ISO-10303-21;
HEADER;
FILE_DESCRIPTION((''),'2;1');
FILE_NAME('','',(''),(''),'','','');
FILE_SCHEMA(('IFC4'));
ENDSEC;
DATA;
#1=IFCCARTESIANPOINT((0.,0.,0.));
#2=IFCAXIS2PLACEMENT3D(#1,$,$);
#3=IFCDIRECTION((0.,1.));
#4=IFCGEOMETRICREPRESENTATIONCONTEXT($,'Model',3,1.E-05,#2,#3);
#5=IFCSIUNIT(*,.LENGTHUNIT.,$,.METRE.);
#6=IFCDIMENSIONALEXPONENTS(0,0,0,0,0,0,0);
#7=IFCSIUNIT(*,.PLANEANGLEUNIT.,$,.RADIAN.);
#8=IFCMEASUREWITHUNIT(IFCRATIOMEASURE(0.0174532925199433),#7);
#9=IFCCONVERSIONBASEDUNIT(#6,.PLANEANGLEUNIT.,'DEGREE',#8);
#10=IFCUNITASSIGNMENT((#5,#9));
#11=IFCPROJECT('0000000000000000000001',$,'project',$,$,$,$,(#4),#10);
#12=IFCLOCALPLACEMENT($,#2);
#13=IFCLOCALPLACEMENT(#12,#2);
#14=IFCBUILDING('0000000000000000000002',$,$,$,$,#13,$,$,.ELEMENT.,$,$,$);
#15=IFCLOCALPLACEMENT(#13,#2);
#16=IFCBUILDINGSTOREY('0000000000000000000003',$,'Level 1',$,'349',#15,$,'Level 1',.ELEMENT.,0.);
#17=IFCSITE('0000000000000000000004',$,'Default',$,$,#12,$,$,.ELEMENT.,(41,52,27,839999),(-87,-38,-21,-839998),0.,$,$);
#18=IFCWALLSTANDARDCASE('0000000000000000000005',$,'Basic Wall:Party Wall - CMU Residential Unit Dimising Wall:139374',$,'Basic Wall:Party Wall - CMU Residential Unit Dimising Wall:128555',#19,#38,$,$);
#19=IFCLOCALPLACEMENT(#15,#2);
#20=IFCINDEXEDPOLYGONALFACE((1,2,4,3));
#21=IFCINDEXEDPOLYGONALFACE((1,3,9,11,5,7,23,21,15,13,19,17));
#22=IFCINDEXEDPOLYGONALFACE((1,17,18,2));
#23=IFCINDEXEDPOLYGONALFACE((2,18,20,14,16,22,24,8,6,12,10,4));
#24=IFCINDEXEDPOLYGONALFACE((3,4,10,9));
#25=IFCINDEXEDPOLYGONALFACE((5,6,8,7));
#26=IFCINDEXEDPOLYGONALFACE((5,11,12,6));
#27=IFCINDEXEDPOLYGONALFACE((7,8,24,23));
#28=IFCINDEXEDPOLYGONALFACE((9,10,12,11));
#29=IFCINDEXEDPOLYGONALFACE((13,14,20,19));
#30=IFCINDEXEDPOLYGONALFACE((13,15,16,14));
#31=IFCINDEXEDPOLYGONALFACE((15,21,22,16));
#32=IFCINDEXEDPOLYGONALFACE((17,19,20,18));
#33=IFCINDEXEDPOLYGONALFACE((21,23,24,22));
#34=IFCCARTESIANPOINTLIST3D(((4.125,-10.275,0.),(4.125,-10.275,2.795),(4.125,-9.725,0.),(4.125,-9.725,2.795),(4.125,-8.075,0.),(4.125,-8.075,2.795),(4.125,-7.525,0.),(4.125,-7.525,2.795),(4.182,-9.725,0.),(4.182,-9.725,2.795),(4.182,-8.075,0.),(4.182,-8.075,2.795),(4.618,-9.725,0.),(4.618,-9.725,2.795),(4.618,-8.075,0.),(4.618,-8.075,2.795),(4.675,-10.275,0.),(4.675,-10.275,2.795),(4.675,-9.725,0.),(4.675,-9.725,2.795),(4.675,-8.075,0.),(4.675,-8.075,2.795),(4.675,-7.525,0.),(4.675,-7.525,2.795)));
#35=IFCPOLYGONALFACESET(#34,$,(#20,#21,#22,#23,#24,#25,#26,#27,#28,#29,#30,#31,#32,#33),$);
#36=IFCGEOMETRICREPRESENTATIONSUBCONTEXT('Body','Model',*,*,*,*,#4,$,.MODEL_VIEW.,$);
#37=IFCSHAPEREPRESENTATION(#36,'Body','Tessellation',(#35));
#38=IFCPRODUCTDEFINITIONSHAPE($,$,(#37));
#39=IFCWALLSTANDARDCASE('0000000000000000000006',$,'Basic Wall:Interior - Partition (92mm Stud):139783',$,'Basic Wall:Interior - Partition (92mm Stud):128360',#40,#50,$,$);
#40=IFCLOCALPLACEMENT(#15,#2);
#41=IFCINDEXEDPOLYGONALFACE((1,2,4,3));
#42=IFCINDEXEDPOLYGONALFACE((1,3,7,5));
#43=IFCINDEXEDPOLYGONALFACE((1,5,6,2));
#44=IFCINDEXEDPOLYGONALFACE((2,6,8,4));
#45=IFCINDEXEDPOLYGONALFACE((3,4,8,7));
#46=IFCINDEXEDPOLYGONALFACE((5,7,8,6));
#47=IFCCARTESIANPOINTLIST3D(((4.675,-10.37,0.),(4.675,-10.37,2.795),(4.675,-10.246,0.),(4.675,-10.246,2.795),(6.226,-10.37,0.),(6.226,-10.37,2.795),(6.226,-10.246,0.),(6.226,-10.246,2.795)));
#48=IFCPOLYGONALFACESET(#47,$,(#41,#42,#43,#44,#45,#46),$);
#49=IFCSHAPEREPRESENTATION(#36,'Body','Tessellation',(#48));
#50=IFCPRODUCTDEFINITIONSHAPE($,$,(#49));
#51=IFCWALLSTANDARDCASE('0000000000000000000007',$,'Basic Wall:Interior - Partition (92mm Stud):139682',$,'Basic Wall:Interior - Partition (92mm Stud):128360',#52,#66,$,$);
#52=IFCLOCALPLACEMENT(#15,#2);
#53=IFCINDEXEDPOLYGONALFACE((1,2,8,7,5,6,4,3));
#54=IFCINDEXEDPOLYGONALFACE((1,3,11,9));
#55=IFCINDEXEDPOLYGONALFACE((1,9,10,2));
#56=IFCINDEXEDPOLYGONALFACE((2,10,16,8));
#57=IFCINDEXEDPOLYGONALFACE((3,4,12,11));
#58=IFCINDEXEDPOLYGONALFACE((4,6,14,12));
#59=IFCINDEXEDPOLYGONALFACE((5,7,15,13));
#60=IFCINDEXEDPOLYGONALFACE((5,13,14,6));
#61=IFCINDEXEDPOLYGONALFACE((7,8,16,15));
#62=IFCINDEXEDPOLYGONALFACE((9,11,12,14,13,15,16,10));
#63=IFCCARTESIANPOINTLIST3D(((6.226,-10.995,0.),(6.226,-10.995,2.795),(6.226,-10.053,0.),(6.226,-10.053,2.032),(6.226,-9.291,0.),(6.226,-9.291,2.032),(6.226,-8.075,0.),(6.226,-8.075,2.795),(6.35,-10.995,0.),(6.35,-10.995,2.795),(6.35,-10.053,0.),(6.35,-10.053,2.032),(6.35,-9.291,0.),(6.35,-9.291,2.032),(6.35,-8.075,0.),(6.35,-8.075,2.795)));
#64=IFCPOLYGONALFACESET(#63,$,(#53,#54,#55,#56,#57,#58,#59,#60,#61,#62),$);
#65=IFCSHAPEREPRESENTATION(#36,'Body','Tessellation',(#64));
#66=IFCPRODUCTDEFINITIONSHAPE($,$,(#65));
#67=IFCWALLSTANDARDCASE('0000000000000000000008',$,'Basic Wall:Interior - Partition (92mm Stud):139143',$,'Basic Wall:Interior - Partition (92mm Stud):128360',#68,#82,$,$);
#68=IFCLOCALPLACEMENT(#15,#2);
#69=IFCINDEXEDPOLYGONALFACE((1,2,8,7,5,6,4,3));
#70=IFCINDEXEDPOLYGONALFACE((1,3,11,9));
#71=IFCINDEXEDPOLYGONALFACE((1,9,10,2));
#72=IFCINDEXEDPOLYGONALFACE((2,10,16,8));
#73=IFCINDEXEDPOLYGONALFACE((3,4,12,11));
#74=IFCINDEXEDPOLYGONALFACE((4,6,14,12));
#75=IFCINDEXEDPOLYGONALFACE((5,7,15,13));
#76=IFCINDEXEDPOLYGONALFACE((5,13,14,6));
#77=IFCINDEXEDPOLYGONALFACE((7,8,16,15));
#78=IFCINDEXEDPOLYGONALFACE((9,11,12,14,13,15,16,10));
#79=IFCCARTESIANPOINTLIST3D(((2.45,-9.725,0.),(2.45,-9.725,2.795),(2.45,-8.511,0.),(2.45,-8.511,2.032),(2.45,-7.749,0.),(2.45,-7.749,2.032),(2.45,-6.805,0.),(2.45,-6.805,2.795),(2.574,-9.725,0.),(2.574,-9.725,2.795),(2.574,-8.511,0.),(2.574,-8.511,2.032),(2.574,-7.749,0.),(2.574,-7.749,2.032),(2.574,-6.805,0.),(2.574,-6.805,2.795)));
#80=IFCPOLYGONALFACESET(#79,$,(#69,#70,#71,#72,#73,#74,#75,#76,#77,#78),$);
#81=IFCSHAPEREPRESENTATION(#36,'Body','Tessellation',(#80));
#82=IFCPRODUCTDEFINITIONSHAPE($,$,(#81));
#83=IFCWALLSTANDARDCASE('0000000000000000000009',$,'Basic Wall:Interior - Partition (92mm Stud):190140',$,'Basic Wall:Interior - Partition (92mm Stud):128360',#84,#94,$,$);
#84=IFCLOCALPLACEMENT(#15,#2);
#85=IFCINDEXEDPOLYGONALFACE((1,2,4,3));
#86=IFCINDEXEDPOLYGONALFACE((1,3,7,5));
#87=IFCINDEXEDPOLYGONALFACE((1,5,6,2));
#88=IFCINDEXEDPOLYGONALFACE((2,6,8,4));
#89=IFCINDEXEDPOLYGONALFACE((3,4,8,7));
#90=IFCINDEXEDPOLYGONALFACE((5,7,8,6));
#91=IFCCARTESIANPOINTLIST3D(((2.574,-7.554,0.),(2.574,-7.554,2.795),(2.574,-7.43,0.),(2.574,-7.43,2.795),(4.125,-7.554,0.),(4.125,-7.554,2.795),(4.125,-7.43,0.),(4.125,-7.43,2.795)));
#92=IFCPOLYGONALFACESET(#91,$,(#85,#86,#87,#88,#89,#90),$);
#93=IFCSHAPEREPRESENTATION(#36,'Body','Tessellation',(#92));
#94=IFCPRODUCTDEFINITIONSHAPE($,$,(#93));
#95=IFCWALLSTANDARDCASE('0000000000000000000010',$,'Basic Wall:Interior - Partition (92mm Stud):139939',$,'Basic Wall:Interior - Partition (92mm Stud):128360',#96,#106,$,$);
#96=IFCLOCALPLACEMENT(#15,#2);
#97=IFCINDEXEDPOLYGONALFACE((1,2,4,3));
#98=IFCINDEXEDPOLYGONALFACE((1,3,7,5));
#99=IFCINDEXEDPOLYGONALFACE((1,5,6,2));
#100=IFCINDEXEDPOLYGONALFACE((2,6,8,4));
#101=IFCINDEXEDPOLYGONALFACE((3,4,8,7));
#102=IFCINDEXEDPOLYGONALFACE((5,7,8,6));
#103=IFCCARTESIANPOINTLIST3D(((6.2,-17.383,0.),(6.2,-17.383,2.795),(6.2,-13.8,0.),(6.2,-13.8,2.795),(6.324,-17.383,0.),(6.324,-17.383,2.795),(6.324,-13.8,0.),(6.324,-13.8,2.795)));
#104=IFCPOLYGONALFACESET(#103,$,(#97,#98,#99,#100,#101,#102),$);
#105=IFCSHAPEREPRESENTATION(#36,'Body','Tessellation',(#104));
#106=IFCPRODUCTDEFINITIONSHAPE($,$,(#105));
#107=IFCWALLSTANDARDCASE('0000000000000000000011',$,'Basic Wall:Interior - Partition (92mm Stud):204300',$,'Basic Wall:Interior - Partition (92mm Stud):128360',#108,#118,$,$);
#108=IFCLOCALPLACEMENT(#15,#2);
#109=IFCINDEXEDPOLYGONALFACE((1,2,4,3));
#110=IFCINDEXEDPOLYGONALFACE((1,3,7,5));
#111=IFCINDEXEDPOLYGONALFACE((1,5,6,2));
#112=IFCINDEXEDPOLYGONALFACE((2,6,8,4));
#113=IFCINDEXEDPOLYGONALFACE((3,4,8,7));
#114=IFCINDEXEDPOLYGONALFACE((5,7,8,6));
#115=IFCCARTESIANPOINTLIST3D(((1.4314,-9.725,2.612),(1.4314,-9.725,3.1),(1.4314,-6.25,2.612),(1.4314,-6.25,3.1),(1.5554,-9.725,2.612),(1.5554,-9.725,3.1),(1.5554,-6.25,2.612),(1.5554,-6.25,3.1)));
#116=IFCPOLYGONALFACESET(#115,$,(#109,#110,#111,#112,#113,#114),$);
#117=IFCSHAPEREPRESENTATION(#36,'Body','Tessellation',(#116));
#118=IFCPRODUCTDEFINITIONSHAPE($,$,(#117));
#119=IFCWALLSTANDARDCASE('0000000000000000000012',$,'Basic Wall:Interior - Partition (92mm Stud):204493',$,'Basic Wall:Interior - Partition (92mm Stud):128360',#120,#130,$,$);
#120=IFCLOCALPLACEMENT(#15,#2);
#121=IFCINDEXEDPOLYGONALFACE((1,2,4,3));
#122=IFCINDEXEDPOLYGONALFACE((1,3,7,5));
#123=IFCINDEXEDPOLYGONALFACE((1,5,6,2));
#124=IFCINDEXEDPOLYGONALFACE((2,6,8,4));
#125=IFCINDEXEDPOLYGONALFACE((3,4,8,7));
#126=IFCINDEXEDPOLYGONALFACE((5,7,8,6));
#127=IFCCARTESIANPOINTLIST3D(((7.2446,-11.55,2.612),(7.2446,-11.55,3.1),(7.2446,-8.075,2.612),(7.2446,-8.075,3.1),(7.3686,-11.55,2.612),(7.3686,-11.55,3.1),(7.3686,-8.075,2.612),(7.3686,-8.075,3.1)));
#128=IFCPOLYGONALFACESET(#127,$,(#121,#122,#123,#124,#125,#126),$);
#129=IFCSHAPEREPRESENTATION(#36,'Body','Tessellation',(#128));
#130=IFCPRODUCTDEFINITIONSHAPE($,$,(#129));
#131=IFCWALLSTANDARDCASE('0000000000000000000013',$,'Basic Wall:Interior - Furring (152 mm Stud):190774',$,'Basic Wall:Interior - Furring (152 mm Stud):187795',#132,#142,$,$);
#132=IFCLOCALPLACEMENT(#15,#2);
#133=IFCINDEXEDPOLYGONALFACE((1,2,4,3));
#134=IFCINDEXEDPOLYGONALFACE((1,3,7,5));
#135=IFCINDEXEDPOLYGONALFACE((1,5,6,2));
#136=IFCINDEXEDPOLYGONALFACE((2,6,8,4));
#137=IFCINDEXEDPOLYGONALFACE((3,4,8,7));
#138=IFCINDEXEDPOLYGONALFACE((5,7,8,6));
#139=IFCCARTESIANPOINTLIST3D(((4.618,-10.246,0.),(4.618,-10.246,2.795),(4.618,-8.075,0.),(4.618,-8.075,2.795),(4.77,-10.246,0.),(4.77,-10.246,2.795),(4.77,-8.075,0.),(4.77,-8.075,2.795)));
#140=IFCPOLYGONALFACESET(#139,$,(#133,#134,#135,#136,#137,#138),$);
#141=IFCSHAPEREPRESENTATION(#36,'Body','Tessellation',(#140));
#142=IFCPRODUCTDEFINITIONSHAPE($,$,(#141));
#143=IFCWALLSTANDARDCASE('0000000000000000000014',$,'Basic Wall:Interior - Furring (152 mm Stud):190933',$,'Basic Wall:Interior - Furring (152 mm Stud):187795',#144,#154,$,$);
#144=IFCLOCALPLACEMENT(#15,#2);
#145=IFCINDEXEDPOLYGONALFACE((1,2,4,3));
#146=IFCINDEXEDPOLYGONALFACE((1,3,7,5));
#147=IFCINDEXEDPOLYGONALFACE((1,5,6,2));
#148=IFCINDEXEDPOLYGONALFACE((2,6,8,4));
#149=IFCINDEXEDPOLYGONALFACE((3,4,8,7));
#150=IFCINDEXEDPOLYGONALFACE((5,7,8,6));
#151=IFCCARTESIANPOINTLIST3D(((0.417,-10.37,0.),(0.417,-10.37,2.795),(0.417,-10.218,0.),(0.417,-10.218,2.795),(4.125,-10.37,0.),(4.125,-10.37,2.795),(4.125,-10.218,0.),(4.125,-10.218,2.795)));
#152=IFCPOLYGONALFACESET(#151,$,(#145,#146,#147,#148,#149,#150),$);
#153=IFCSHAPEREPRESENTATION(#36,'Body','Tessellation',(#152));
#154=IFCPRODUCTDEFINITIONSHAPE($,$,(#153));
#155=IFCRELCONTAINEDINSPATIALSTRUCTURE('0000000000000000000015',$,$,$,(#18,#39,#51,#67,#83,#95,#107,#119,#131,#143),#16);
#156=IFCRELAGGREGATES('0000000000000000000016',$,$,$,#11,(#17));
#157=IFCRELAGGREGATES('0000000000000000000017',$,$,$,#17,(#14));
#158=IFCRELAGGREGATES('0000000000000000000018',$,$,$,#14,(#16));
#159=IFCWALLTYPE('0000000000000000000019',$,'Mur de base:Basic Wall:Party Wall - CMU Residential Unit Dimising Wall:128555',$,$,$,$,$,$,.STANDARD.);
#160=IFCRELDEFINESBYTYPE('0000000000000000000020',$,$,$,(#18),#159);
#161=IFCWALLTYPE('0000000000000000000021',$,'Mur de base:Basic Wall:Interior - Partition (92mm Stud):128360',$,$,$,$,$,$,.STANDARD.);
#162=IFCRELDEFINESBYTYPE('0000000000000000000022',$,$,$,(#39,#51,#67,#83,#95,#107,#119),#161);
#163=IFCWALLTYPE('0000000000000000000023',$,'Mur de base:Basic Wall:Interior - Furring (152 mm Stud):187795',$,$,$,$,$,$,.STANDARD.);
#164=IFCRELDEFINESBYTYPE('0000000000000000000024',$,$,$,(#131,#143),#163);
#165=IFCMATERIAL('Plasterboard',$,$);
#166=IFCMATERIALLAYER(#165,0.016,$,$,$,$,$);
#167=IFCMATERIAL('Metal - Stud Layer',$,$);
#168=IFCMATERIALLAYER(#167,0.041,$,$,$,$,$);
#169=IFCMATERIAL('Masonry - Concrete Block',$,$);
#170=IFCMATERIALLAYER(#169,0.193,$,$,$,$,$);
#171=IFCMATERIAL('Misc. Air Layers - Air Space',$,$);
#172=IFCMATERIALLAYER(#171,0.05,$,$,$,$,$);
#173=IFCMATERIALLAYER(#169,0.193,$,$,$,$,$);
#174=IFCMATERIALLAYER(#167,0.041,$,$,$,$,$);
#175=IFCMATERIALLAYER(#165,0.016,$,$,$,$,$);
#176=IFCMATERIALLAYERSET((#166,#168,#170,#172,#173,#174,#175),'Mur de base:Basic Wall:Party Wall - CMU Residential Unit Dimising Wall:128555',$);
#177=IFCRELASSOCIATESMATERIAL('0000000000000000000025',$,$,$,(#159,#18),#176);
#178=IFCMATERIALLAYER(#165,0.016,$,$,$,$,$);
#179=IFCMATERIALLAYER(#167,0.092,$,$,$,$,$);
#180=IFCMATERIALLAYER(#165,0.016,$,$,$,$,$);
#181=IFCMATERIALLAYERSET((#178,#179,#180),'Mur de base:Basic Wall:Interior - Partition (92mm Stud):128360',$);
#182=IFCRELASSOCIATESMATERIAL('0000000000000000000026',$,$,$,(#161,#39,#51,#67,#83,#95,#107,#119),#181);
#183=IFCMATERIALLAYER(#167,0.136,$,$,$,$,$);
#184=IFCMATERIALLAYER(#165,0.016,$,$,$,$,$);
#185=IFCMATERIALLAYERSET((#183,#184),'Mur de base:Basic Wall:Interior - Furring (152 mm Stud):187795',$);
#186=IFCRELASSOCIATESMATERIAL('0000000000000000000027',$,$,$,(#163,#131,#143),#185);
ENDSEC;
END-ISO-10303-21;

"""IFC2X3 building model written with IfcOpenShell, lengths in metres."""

from ifc_helpers import new_model, entity, si_unit, converted_unit, direction, frame, frame_2d, origin, origin_2d_with_axis, place, context, subcontext, project, spatial, rectangle, extrude, material, layer, layer_set, layer_usage, type_object, element, save


model = new_model("IFC2X3")

# Units and contexts
model_context = context("Model", 3, precision=1e-05, world=origin(), true_north=direction((0.0, 1.0)))
body_context = subcontext(model_context, "Body", "Model", "MODEL_VIEW")
ifc_project = project(units=[si_unit("LENGTHUNIT", "METRE"), converted_unit("PLANEANGLEUNIT", "DEGREE", entity("IfcRatioMeasure", 0.0174532925199433), si_unit("PLANEANGLEUNIT", "RADIAN"), dimensions=[0, 0, 0, 0, 0, 0, 0])], contexts=[model_context])

# Site, building, storey
site_placement = place(None, origin())
site = spatial("IfcSite", under=ifc_project, at=site_placement, Name="Default", CompositionType="ELEMENT", RefLatitude=(41, 52, 27, 839999), RefLongitude=(-87, -38, -21, -839998), RefElevation=0.0)
building_placement = place(site_placement, origin())
building = spatial("IfcBuilding", under=site, at=building_placement, CompositionType="ELEMENT")
storey_placement = place(building_placement, origin())
storey = spatial("IfcBuildingStorey", under=building, at=storey_placement, Name="Level 1", ObjectType="349", LongName="Level 1", CompositionType="ELEMENT", Elevation=0.0)

# Wall, opening
ifc_material_1 = material(Name="Plasterboard")
ifc_layer_1 = layer(ifc_material_1, 0.016)
ifc_material_2 = material(Name="Metal - Stud Layer")
ifc_layer_2 = layer(ifc_material_2, 0.041)
ifc_material_3 = material(Name="Masonry - Concrete Block")
ifc_layer_3 = layer(ifc_material_3, 0.193)
ifc_material_4 = material(Name="Misc. Air Layers - Air Space")
ifc_layer_4 = layer(ifc_material_4, 0.05)
ifc_layer_5 = layer(ifc_material_3, 0.193)
ifc_layer_6 = layer(ifc_material_2, 0.041)
ifc_layer_7 = layer(ifc_material_1, 0.016)
ifc_layer_set_1 = layer_set([ifc_layer_1, ifc_layer_2, ifc_layer_3, ifc_layer_4, ifc_layer_5, ifc_layer_6, ifc_layer_7], Name="Mur de base:Basic Wall:Party Wall - CMU Residential Unit Dimising Wall:128555")
ifc_layer_usage_1 = layer_usage(ifc_layer_set_1, "AXIS2", "NEGATIVE", 0.275)
wall_type_1 = type_object("IfcWallType", Name="Mur de base:Basic Wall:Party Wall - CMU Residential Unit Dimising Wall:128555", PredefinedType="STANDARD", material=ifc_layer_set_1)
wall_1_placement = place(storey_placement, frame((4.4, -10.275, 0.0), z_axis=(0.0, 0.0, 1.0), x_axis=(0.0, 1.0, 0.0)))
wall_1 = element("IfcWallStandardCase", 1, at=wall_1_placement, inside=storey, type_object=wall_type_1, material=ifc_layer_usage_1, Name="Basic Wall:Party Wall - CMU Residential Unit Dimising Wall:139374", ObjectType="Basic Wall:Party Wall - CMU Residential Unit Dimising Wall:128555", context=body_context, shape_type="SweptSolid", body=[
    extrude(rectangle(XDim=2.75, YDim=0.55, at=frame_2d((1.375, 0.0), x_axis=(-1.0, 0.0))), origin(), (0.0, 0.0, 1.0), 2.795),
])
opening_1_placement = place(wall_1_placement, origin())
element("IfcOpeningElement", 2, at=opening_1_placement, cuts=wall_1, ObjectType="Opening", context=body_context, shape_type="SweptSolid", body=[
    extrude(rectangle(XDim=2.795, YDim=1.65, at=origin_2d_with_axis()), frame((1.375, 0.218, 1.3975), z_axis=(0.0, 1.0, 0.0), x_axis=(0.0, 0.0, 1.0)), (0.0, 0.0, 1.0), 3.904),
    extrude(rectangle(XDim=2.795, YDim=1.65, at=frame_2d((0.0, 0.0), x_axis=(0.0, 1.0))), frame((1.375, -4.122, 1.3975), z_axis=(0.0, 1.0, 0.0), x_axis=(-1.0, 0.0, 0.0)), (0.0, 0.0, 1.0), 3.904),
])

# Wall
ifc_layer_8 = layer(ifc_material_1, 0.016)
ifc_layer_9 = layer(ifc_material_2, 0.092)
ifc_layer_10 = layer(ifc_material_1, 0.016)
ifc_layer_set_2 = layer_set([ifc_layer_8, ifc_layer_9, ifc_layer_10], Name="Mur de base:Basic Wall:Interior - Partition (92mm Stud):128360")
ifc_layer_usage_2 = layer_usage(ifc_layer_set_2, "AXIS2", "NEGATIVE", 0.062)
wall_type_2 = type_object("IfcWallType", Name="Mur de base:Basic Wall:Interior - Partition (92mm Stud):128360", PredefinedType="STANDARD", material=ifc_layer_set_2)
wall_2_placement = place(storey_placement, frame((4.675, -10.308, 0.0)))
element("IfcWallStandardCase", 3, at=wall_2_placement, inside=storey, type_object=wall_type_2, material=ifc_layer_usage_2, Name="Basic Wall:Interior - Partition (92mm Stud):139783", ObjectType="Basic Wall:Interior - Partition (92mm Stud):128360", context=body_context, shape_type="SweptSolid", body=[
    extrude(rectangle(XDim=1.551, YDim=0.124, at=frame_2d((0.7755, 0.0), x_axis=(-1.0, 0.0))), origin(), (0.0, 0.0, 1.0), 2.795),
])

# Walls, openings
ifc_layer_usage_3 = layer_usage(ifc_layer_set_2, "AXIS2", "NEGATIVE", 0.062)
wall_3_placement = place(storey_placement, frame((6.288, -10.995, 0.0), z_axis=(0.0, 0.0, 1.0), x_axis=(0.0, 1.0, 0.0)))
wall_3 = element("IfcWallStandardCase", 4, at=wall_3_placement, inside=storey, type_object=wall_type_2, material=ifc_layer_usage_3, Name="Basic Wall:Interior - Partition (92mm Stud):139682", ObjectType="Basic Wall:Interior - Partition (92mm Stud):128360", context=body_context, shape_type="SweptSolid", body=[
    extrude(rectangle(XDim=2.92, YDim=0.124, at=frame_2d((1.46, 0.0), x_axis=(-1.0, 0.0))), origin(), (0.0, 0.0, 1.0), 2.795),
])
opening_2_placement = place(wall_3_placement, origin())
element("IfcOpeningElement", 5, at=opening_2_placement, cuts=wall_3, ObjectType="Opening", context=body_context, shape_type="SweptSolid", body=[
    extrude(rectangle(XDim=2.032, YDim=0.762, at=origin_2d_with_axis()), frame((1.323, -0.0632, 1.016), z_axis=(0.0, 1.0, 0.0), x_axis=(0.0, 0.0, 1.0)), (0.0, 0.0, 1.0), 0.1265),
])
ifc_layer_usage_4 = layer_usage(ifc_layer_set_2, "AXIS2", "NEGATIVE", 0.062)
wall_4_placement = place(storey_placement, frame((2.512, -6.805, 0.0), z_axis=(0.0, 0.0, 1.0), x_axis=(0.0, -1.0, 0.0)))
wall_4 = element("IfcWallStandardCase", 6, at=wall_4_placement, inside=storey, type_object=wall_type_2, material=ifc_layer_usage_4, Name="Basic Wall:Interior - Partition (92mm Stud):139143", ObjectType="Basic Wall:Interior - Partition (92mm Stud):128360", context=body_context, shape_type="SweptSolid", body=[
    extrude(rectangle(XDim=2.92, YDim=0.124, at=frame_2d((1.46, 0.0), x_axis=(-1.0, 0.0))), origin(), (0.0, 0.0, 1.0), 2.795),
])
opening_3_placement = place(wall_4_placement, origin())
element("IfcOpeningElement", 7, at=opening_3_placement, cuts=wall_4, ObjectType="Opening", context=body_context, shape_type="SweptSolid", body=[
    extrude(rectangle(XDim=2.032, YDim=0.762, at=origin_2d_with_axis()), frame((1.325, -0.0632, 1.016), z_axis=(0.0, 1.0, 0.0), x_axis=(0.0, 0.0, 1.0)), (0.0, 0.0, 1.0), 0.1265),
])

# Walls
ifc_layer_usage_5 = layer_usage(ifc_layer_set_2, "AXIS2", "NEGATIVE", 0.062)
wall_5_placement = place(storey_placement, frame((4.125, -7.492, 0.0), z_axis=(0.0, 0.0, 1.0), x_axis=(-1.0, 0.0, 0.0)))
element("IfcWallStandardCase", 8, at=wall_5_placement, inside=storey, type_object=wall_type_2, material=ifc_layer_usage_5, Name="Basic Wall:Interior - Partition (92mm Stud):190140", ObjectType="Basic Wall:Interior - Partition (92mm Stud):128360", context=body_context, shape_type="SweptSolid", body=[
    extrude(rectangle(XDim=1.551, YDim=0.124, at=frame_2d((0.7755, 0.0), x_axis=(-1.0, 0.0))), origin(), (0.0, 0.0, 1.0), 2.795),
])
ifc_layer_usage_6 = layer_usage(ifc_layer_set_2, "AXIS2", "NEGATIVE", 0.062)
wall_6_placement = place(storey_placement, frame((6.262, -13.8, 0.0), z_axis=(0.0, 0.0, 1.0), x_axis=(0.0, -1.0, 0.0)))
element("IfcWallStandardCase", 9, at=wall_6_placement, inside=storey, type_object=wall_type_2, material=ifc_layer_usage_6, Name="Basic Wall:Interior - Partition (92mm Stud):139939", ObjectType="Basic Wall:Interior - Partition (92mm Stud):128360", context=body_context, shape_type="SweptSolid", body=[
    extrude(rectangle(XDim=3.583, YDim=0.124, at=frame_2d((1.7915, 0.0), x_axis=(-1.0, 0.0))), origin(), (0.0, 0.0, 1.0), 2.795),
])
ifc_layer_usage_7 = layer_usage(ifc_layer_set_2, "AXIS2", "NEGATIVE", 0.062)
wall_7_placement = place(storey_placement, frame((1.4934, -6.25, 2.612), z_axis=(0.0, 0.0, 1.0), x_axis=(0.0, -1.0, 0.0)))
element("IfcWallStandardCase", 10, at=wall_7_placement, inside=storey, type_object=wall_type_2, material=ifc_layer_usage_7, Name="Basic Wall:Interior - Partition (92mm Stud):204300", ObjectType="Basic Wall:Interior - Partition (92mm Stud):128360", context=body_context, shape_type="SweptSolid", body=[
    extrude(rectangle(XDim=3.475, YDim=0.124, at=frame_2d((1.7375, 0.0), x_axis=(-1.0, 0.0))), origin(), (0.0, 0.0, 1.0), 0.488),
])
ifc_layer_usage_8 = layer_usage(ifc_layer_set_2, "AXIS2", "NEGATIVE", 0.062)
wall_8_placement = place(storey_placement, frame((7.3066, -11.55, 2.612), z_axis=(0.0, 0.0, 1.0), x_axis=(0.0, 1.0, 0.0)))
element("IfcWallStandardCase", 11, at=wall_8_placement, inside=storey, type_object=wall_type_2, material=ifc_layer_usage_8, Name="Basic Wall:Interior - Partition (92mm Stud):204493", ObjectType="Basic Wall:Interior - Partition (92mm Stud):128360", context=body_context, shape_type="SweptSolid", body=[
    extrude(rectangle(XDim=3.475, YDim=0.124, at=frame_2d((1.7375, 0.0), x_axis=(-1.0, 0.0))), origin(), (0.0, 0.0, 1.0), 0.488),
])

# Walls
ifc_layer_11 = layer(ifc_material_2, 0.136)
ifc_layer_12 = layer(ifc_material_1, 0.016)
ifc_layer_set_3 = layer_set([ifc_layer_11, ifc_layer_12], Name="Mur de base:Basic Wall:Interior - Furring (152 mm Stud):187795")
ifc_layer_usage_9 = layer_usage(ifc_layer_set_3, "AXIS2", "NEGATIVE", 0.076)
wall_type_3 = type_object("IfcWallType", Name="Mur de base:Basic Wall:Interior - Furring (152 mm Stud):187795", PredefinedType="STANDARD", material=ifc_layer_set_3)
wall_9_placement = place(storey_placement, frame((4.694, -10.246, 0.0), z_axis=(0.0, 0.0, 1.0), x_axis=(0.0, 1.0, 0.0)))
element("IfcWallStandardCase", 12, at=wall_9_placement, inside=storey, type_object=wall_type_3, material=ifc_layer_usage_9, Name="Basic Wall:Interior - Furring (152 mm Stud):190774", ObjectType="Basic Wall:Interior - Furring (152 mm Stud):187795", context=body_context, shape_type="SweptSolid", body=[
    extrude(rectangle(XDim=2.171, YDim=0.152, at=frame_2d((1.0855, 0.0), x_axis=(-1.0, 0.0))), origin(), (0.0, 0.0, 1.0), 2.795),
])
ifc_layer_usage_10 = layer_usage(ifc_layer_set_3, "AXIS2", "NEGATIVE", 0.076)
wall_10_placement = place(storey_placement, frame((0.417, -10.294, 0.0)))
element("IfcWallStandardCase", 13, at=wall_10_placement, inside=storey, type_object=wall_type_3, material=ifc_layer_usage_10, Name="Basic Wall:Interior - Furring (152 mm Stud):190933", ObjectType="Basic Wall:Interior - Furring (152 mm Stud):187795", context=body_context, shape_type="SweptSolid", body=[
    extrude(rectangle(XDim=3.708, YDim=0.152, at=frame_2d((1.854, 0.0), x_axis=(-1.0, 0.0))), origin(), (0.0, 0.0, 1.0), 2.795),
])

save(model, "model.ifc")
